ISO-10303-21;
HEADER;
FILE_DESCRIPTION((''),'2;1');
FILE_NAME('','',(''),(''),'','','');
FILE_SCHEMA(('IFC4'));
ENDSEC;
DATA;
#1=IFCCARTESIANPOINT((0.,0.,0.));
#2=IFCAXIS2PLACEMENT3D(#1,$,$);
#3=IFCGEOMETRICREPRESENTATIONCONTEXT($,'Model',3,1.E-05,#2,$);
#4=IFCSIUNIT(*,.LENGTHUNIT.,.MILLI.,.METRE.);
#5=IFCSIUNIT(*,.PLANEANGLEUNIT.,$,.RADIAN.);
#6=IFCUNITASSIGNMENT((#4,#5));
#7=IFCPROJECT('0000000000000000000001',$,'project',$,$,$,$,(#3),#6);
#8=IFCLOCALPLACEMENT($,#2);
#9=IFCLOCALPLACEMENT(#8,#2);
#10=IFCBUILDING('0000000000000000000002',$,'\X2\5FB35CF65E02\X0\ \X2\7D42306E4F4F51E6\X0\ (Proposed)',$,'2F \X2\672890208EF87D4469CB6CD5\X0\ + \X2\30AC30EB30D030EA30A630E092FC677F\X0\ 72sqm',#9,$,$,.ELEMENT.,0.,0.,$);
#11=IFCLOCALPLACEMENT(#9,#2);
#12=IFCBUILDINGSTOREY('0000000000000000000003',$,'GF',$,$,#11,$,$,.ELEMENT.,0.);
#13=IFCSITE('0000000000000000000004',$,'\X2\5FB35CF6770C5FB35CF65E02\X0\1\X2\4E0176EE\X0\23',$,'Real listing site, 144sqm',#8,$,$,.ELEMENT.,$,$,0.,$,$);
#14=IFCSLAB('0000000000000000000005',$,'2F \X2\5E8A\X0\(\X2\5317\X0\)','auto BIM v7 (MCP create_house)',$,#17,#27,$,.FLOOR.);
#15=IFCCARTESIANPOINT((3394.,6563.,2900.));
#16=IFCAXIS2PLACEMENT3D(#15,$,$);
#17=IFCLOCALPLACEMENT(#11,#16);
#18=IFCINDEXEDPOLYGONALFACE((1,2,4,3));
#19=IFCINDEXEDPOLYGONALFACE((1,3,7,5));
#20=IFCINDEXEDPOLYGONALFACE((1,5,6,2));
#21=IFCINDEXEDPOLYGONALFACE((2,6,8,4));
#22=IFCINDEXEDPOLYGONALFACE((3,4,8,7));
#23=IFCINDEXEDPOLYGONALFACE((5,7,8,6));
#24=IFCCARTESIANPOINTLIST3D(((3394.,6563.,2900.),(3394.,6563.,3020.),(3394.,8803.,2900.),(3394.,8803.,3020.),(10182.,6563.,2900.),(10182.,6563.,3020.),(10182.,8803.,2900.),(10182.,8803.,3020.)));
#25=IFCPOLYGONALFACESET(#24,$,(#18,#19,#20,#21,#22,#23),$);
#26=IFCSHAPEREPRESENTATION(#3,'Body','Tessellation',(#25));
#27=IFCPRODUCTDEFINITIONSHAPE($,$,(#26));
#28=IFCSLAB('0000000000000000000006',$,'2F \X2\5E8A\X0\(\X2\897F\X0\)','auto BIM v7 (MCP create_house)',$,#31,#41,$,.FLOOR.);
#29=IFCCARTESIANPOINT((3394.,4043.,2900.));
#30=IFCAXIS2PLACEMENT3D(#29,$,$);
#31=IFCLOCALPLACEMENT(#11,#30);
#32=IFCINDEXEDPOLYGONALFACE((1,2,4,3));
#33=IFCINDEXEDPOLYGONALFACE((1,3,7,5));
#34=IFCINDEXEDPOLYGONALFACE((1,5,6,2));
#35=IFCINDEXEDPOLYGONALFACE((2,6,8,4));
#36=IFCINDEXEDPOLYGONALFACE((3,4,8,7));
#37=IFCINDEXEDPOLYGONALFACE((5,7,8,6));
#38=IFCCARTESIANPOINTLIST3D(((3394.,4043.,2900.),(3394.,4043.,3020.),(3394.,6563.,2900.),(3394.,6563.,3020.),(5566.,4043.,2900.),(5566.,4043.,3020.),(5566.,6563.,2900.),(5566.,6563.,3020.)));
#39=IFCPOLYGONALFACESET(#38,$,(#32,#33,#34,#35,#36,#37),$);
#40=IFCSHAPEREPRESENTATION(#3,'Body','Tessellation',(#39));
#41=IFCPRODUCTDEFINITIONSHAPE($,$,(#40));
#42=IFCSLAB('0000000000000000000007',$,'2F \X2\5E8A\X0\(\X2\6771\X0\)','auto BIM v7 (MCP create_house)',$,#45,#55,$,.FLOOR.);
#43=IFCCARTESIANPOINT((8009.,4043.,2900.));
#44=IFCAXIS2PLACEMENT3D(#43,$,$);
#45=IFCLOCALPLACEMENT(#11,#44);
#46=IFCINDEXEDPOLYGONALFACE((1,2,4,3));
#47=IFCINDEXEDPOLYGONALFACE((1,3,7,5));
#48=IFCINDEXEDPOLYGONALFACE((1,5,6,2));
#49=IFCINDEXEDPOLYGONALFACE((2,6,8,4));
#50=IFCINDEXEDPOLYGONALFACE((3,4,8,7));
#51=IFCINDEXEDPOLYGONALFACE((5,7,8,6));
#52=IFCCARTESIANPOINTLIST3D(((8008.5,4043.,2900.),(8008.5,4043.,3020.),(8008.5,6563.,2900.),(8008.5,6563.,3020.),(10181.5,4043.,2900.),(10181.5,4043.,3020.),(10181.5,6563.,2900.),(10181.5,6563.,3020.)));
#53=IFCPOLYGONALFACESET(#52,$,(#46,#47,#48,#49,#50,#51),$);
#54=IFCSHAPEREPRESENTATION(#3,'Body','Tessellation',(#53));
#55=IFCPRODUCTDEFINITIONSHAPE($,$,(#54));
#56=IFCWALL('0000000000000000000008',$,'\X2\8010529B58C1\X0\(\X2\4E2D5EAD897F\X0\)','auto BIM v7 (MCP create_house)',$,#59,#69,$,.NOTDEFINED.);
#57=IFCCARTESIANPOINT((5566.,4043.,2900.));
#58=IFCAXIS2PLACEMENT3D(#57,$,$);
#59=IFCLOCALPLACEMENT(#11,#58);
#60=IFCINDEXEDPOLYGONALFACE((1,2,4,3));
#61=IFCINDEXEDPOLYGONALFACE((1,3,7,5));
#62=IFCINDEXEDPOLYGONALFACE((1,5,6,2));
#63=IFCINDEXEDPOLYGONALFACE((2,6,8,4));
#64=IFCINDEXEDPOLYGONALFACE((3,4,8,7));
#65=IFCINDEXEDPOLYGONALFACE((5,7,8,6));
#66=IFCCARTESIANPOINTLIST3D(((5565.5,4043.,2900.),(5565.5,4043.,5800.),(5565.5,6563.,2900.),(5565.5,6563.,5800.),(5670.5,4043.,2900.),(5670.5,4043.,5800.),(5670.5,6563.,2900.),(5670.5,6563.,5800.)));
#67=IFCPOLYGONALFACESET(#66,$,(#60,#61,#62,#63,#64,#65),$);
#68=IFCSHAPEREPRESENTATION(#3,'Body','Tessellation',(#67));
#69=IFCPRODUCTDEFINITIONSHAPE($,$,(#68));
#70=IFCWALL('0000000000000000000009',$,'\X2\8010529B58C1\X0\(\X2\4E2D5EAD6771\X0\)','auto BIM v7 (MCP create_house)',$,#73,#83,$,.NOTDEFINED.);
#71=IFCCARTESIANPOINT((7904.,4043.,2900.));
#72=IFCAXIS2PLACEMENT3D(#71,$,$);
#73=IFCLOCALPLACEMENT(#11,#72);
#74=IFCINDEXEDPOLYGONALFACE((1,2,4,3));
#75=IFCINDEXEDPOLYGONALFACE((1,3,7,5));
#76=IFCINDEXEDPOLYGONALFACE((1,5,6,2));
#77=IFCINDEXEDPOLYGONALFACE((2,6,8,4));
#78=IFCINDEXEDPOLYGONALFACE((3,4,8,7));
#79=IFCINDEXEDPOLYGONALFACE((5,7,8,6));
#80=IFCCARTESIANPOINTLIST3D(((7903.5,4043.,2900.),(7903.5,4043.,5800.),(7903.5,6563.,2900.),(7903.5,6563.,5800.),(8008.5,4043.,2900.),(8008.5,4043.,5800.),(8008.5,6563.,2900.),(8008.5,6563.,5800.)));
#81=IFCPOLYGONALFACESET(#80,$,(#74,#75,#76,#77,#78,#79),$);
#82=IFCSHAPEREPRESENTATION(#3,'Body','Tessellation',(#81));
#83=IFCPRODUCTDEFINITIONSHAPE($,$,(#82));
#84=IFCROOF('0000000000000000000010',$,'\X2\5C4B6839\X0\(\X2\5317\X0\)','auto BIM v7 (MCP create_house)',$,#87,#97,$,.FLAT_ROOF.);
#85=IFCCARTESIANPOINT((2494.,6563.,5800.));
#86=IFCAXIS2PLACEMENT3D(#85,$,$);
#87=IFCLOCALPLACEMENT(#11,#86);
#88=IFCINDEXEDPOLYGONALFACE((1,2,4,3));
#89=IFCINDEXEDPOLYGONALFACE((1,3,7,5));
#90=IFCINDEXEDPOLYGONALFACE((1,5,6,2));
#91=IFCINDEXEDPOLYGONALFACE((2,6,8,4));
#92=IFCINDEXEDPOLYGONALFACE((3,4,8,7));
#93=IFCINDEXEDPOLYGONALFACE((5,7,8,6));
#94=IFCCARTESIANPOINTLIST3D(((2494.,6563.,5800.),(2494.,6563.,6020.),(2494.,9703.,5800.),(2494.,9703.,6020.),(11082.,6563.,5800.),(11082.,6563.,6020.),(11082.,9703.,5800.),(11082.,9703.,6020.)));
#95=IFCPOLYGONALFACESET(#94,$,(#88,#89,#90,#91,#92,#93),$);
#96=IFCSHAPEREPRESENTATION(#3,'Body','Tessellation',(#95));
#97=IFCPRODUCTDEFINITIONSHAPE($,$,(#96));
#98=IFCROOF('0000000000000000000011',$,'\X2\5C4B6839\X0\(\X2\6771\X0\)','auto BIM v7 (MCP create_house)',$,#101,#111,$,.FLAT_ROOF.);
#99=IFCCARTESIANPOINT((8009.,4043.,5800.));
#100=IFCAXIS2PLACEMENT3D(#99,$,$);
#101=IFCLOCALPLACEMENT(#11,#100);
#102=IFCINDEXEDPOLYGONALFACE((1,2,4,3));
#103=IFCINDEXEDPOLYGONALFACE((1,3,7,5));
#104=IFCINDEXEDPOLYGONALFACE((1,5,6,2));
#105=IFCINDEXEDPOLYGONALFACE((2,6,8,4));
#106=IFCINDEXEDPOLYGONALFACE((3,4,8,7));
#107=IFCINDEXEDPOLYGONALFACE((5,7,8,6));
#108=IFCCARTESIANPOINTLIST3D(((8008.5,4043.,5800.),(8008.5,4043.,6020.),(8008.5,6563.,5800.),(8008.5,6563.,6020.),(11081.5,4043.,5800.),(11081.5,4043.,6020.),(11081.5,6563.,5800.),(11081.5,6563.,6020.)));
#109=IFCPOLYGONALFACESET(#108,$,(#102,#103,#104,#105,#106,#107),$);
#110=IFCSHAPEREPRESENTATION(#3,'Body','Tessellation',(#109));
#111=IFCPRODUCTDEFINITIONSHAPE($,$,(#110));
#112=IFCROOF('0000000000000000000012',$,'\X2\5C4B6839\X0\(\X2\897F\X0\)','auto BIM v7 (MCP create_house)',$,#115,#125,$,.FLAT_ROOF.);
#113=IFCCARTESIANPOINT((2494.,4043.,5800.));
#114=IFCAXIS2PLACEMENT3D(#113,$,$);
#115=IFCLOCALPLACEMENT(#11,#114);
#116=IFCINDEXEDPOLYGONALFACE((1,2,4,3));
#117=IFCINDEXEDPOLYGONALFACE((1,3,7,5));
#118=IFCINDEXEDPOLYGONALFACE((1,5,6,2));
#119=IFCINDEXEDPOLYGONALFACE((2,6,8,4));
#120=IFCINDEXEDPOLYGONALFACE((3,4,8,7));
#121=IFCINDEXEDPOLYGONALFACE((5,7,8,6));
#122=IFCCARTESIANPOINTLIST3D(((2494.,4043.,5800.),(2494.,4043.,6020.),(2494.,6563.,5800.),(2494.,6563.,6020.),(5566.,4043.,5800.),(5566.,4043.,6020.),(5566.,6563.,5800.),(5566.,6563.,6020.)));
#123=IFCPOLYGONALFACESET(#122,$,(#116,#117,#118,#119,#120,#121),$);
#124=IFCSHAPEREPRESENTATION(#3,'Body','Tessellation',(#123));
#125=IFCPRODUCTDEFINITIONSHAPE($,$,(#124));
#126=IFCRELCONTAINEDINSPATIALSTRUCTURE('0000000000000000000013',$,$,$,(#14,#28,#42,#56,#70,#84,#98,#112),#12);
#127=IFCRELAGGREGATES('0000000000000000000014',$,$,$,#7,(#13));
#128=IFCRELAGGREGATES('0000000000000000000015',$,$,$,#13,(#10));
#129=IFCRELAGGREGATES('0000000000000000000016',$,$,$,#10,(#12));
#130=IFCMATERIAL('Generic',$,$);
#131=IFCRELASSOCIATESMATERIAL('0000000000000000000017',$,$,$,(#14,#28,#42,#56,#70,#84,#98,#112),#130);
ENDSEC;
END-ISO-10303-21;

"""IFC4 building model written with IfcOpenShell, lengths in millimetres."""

from ifc_helpers import new_model, si_unit, frame, frame_2d, origin, place, context, project, spatial, rectangle, extrude, material, element, save


model = new_model("IFC4")

# Units and contexts
model_context = context("Model", 3, precision=1e-05, world=origin())
ifc_project = project(units=[si_unit("LENGTHUNIT", "METRE", prefix="MILLI"), si_unit("PLANEANGLEUNIT", "RADIAN")], contexts=[model_context])

# Site, building, storey
site_placement = place(None, origin())
site = spatial("IfcSite", under=ifc_project, at=site_placement, Name="徳島県徳島市1丁目23", ObjectType="Real listing site, 144sqm", CompositionType="ELEMENT", RefElevation=0.0)
building_placement = place(site_placement, origin())
building = spatial("IfcBuilding", under=site, at=building_placement, Name="徳島市 終の住処 (Proposed)", ObjectType="2F 木造軸組構法 + ガルバリウム鋼板 72sqm", CompositionType="ELEMENT", ElevationOfRefHeight=0.0, ElevationOfTerrain=0.0)
storey_placement = place(building_placement, origin())
storey = spatial("IfcBuildingStorey", under=building, at=storey_placement, Name="GF", CompositionType="ELEMENT", Elevation=0.0)

# Slabs
ifc_material = material(Name="Generic")
slab_1_placement = place(storey_placement, frame((3394.0, 6563.0, 2900.0)))
element("IfcSlab", 1, at=slab_1_placement, inside=storey, material=ifc_material, Name="2F 床(北)", Description="auto BIM v7 (MCP create_house)", PredefinedType="FLOOR", context=model_context, shape_type="SweptSolid", body=[
    extrude(rectangle(XDim=6788.0, YDim=2240.0, at=frame_2d((3394.0, 1120.0))), frame((3394.0, 6563.0, 2900.0)), (0.0, 0.0, 1.0), 120.0),
])
slab_2_placement = place(storey_placement, frame((3394.0, 4043.0, 2900.0)))
element("IfcSlab", 2, at=slab_2_placement, inside=storey, material=ifc_material, Name="2F 床(西)", Description="auto BIM v7 (MCP create_house)", PredefinedType="FLOOR", context=model_context, shape_type="SweptSolid", body=[
    extrude(rectangle(XDim=2172.0, YDim=2520.0, at=frame_2d((1086.0, 1260.0))), frame((3394.0, 4043.0, 2900.0)), (0.0, 0.0, 1.0), 120.0),
])
slab_3_placement = place(storey_placement, frame((8009.0, 4043.0, 2900.0)))
element("IfcSlab", 3, at=slab_3_placement, inside=storey, material=ifc_material, Name="2F 床(東)", Description="auto BIM v7 (MCP create_house)", PredefinedType="FLOOR", context=model_context, shape_type="SweptSolid", body=[
    extrude(rectangle(XDim=2173.0, YDim=2520.0, at=frame_2d((1086.0, 1260.0))), frame((8009.0, 4043.0, 2900.0)), (0.0, 0.0, 1.0), 120.0),
])

# Walls
wall_1_placement = place(storey_placement, frame((5566.0, 4043.0, 2900.0)))
element("IfcWall", 4, at=wall_1_placement, inside=storey, material=ifc_material, Name="耐力壁(中庭西)", Description="auto BIM v7 (MCP create_house)", PredefinedType="NOTDEFINED", context=model_context, shape_type="SweptSolid", body=[
    extrude(rectangle(XDim=105.0, YDim=2520.0, at=frame_2d((52.0, 1260.0))), frame((5566.0, 4043.0, 2900.0)), (0.0, 0.0, 1.0), 2900.0),
])
wall_2_placement = place(storey_placement, frame((7904.0, 4043.0, 2900.0)))
element("IfcWall", 5, at=wall_2_placement, inside=storey, material=ifc_material, Name="耐力壁(中庭東)", Description="auto BIM v7 (MCP create_house)", PredefinedType="NOTDEFINED", context=model_context, shape_type="SweptSolid", body=[
    extrude(rectangle(XDim=105.0, YDim=2520.0, at=frame_2d((52.0, 1260.0))), frame((7904.0, 4043.0, 2900.0)), (0.0, 0.0, 1.0), 2900.0),
])

# Roofs
roof_1_placement = place(storey_placement, frame((2494.0, 6563.0, 5800.0)))
element("IfcRoof", 6, at=roof_1_placement, inside=storey, material=ifc_material, Name="屋根(北)", Description="auto BIM v7 (MCP create_house)", PredefinedType="FLAT_ROOF", context=model_context, shape_type="SweptSolid", body=[
    extrude(rectangle(XDim=8588.0, YDim=3140.0, at=frame_2d((4294.0, 1570.0))), frame((2494.0, 6563.0, 5800.0)), (0.0, 0.0, 1.0), 220.0),
])
roof_2_placement = place(storey_placement, frame((8009.0, 4043.0, 5800.0)))
element("IfcRoof", 7, at=roof_2_placement, inside=storey, material=ifc_material, Name="屋根(東)", Description="auto BIM v7 (MCP create_house)", PredefinedType="FLAT_ROOF", context=model_context, shape_type="SweptSolid", body=[
    extrude(rectangle(XDim=3073.0, YDim=2520.0, at=frame_2d((1536.0, 1260.0))), frame((8009.0, 4043.0, 5800.0)), (0.0, 0.0, 1.0), 220.0),
])
roof_3_placement = place(storey_placement, frame((2494.0, 4043.0, 5800.0)))
element("IfcRoof", 8, at=roof_3_placement, inside=storey, material=ifc_material, Name="屋根(西)", Description="auto BIM v7 (MCP create_house)", PredefinedType="FLAT_ROOF", context=model_context, shape_type="SweptSolid", body=[
    extrude(rectangle(XDim=3072.0, YDim=2520.0, at=frame_2d((1536.0, 1260.0))), frame((2494.0, 4043.0, 5800.0)), (0.0, 0.0, 1.0), 220.0),
])

save(model, "model.ifc")
